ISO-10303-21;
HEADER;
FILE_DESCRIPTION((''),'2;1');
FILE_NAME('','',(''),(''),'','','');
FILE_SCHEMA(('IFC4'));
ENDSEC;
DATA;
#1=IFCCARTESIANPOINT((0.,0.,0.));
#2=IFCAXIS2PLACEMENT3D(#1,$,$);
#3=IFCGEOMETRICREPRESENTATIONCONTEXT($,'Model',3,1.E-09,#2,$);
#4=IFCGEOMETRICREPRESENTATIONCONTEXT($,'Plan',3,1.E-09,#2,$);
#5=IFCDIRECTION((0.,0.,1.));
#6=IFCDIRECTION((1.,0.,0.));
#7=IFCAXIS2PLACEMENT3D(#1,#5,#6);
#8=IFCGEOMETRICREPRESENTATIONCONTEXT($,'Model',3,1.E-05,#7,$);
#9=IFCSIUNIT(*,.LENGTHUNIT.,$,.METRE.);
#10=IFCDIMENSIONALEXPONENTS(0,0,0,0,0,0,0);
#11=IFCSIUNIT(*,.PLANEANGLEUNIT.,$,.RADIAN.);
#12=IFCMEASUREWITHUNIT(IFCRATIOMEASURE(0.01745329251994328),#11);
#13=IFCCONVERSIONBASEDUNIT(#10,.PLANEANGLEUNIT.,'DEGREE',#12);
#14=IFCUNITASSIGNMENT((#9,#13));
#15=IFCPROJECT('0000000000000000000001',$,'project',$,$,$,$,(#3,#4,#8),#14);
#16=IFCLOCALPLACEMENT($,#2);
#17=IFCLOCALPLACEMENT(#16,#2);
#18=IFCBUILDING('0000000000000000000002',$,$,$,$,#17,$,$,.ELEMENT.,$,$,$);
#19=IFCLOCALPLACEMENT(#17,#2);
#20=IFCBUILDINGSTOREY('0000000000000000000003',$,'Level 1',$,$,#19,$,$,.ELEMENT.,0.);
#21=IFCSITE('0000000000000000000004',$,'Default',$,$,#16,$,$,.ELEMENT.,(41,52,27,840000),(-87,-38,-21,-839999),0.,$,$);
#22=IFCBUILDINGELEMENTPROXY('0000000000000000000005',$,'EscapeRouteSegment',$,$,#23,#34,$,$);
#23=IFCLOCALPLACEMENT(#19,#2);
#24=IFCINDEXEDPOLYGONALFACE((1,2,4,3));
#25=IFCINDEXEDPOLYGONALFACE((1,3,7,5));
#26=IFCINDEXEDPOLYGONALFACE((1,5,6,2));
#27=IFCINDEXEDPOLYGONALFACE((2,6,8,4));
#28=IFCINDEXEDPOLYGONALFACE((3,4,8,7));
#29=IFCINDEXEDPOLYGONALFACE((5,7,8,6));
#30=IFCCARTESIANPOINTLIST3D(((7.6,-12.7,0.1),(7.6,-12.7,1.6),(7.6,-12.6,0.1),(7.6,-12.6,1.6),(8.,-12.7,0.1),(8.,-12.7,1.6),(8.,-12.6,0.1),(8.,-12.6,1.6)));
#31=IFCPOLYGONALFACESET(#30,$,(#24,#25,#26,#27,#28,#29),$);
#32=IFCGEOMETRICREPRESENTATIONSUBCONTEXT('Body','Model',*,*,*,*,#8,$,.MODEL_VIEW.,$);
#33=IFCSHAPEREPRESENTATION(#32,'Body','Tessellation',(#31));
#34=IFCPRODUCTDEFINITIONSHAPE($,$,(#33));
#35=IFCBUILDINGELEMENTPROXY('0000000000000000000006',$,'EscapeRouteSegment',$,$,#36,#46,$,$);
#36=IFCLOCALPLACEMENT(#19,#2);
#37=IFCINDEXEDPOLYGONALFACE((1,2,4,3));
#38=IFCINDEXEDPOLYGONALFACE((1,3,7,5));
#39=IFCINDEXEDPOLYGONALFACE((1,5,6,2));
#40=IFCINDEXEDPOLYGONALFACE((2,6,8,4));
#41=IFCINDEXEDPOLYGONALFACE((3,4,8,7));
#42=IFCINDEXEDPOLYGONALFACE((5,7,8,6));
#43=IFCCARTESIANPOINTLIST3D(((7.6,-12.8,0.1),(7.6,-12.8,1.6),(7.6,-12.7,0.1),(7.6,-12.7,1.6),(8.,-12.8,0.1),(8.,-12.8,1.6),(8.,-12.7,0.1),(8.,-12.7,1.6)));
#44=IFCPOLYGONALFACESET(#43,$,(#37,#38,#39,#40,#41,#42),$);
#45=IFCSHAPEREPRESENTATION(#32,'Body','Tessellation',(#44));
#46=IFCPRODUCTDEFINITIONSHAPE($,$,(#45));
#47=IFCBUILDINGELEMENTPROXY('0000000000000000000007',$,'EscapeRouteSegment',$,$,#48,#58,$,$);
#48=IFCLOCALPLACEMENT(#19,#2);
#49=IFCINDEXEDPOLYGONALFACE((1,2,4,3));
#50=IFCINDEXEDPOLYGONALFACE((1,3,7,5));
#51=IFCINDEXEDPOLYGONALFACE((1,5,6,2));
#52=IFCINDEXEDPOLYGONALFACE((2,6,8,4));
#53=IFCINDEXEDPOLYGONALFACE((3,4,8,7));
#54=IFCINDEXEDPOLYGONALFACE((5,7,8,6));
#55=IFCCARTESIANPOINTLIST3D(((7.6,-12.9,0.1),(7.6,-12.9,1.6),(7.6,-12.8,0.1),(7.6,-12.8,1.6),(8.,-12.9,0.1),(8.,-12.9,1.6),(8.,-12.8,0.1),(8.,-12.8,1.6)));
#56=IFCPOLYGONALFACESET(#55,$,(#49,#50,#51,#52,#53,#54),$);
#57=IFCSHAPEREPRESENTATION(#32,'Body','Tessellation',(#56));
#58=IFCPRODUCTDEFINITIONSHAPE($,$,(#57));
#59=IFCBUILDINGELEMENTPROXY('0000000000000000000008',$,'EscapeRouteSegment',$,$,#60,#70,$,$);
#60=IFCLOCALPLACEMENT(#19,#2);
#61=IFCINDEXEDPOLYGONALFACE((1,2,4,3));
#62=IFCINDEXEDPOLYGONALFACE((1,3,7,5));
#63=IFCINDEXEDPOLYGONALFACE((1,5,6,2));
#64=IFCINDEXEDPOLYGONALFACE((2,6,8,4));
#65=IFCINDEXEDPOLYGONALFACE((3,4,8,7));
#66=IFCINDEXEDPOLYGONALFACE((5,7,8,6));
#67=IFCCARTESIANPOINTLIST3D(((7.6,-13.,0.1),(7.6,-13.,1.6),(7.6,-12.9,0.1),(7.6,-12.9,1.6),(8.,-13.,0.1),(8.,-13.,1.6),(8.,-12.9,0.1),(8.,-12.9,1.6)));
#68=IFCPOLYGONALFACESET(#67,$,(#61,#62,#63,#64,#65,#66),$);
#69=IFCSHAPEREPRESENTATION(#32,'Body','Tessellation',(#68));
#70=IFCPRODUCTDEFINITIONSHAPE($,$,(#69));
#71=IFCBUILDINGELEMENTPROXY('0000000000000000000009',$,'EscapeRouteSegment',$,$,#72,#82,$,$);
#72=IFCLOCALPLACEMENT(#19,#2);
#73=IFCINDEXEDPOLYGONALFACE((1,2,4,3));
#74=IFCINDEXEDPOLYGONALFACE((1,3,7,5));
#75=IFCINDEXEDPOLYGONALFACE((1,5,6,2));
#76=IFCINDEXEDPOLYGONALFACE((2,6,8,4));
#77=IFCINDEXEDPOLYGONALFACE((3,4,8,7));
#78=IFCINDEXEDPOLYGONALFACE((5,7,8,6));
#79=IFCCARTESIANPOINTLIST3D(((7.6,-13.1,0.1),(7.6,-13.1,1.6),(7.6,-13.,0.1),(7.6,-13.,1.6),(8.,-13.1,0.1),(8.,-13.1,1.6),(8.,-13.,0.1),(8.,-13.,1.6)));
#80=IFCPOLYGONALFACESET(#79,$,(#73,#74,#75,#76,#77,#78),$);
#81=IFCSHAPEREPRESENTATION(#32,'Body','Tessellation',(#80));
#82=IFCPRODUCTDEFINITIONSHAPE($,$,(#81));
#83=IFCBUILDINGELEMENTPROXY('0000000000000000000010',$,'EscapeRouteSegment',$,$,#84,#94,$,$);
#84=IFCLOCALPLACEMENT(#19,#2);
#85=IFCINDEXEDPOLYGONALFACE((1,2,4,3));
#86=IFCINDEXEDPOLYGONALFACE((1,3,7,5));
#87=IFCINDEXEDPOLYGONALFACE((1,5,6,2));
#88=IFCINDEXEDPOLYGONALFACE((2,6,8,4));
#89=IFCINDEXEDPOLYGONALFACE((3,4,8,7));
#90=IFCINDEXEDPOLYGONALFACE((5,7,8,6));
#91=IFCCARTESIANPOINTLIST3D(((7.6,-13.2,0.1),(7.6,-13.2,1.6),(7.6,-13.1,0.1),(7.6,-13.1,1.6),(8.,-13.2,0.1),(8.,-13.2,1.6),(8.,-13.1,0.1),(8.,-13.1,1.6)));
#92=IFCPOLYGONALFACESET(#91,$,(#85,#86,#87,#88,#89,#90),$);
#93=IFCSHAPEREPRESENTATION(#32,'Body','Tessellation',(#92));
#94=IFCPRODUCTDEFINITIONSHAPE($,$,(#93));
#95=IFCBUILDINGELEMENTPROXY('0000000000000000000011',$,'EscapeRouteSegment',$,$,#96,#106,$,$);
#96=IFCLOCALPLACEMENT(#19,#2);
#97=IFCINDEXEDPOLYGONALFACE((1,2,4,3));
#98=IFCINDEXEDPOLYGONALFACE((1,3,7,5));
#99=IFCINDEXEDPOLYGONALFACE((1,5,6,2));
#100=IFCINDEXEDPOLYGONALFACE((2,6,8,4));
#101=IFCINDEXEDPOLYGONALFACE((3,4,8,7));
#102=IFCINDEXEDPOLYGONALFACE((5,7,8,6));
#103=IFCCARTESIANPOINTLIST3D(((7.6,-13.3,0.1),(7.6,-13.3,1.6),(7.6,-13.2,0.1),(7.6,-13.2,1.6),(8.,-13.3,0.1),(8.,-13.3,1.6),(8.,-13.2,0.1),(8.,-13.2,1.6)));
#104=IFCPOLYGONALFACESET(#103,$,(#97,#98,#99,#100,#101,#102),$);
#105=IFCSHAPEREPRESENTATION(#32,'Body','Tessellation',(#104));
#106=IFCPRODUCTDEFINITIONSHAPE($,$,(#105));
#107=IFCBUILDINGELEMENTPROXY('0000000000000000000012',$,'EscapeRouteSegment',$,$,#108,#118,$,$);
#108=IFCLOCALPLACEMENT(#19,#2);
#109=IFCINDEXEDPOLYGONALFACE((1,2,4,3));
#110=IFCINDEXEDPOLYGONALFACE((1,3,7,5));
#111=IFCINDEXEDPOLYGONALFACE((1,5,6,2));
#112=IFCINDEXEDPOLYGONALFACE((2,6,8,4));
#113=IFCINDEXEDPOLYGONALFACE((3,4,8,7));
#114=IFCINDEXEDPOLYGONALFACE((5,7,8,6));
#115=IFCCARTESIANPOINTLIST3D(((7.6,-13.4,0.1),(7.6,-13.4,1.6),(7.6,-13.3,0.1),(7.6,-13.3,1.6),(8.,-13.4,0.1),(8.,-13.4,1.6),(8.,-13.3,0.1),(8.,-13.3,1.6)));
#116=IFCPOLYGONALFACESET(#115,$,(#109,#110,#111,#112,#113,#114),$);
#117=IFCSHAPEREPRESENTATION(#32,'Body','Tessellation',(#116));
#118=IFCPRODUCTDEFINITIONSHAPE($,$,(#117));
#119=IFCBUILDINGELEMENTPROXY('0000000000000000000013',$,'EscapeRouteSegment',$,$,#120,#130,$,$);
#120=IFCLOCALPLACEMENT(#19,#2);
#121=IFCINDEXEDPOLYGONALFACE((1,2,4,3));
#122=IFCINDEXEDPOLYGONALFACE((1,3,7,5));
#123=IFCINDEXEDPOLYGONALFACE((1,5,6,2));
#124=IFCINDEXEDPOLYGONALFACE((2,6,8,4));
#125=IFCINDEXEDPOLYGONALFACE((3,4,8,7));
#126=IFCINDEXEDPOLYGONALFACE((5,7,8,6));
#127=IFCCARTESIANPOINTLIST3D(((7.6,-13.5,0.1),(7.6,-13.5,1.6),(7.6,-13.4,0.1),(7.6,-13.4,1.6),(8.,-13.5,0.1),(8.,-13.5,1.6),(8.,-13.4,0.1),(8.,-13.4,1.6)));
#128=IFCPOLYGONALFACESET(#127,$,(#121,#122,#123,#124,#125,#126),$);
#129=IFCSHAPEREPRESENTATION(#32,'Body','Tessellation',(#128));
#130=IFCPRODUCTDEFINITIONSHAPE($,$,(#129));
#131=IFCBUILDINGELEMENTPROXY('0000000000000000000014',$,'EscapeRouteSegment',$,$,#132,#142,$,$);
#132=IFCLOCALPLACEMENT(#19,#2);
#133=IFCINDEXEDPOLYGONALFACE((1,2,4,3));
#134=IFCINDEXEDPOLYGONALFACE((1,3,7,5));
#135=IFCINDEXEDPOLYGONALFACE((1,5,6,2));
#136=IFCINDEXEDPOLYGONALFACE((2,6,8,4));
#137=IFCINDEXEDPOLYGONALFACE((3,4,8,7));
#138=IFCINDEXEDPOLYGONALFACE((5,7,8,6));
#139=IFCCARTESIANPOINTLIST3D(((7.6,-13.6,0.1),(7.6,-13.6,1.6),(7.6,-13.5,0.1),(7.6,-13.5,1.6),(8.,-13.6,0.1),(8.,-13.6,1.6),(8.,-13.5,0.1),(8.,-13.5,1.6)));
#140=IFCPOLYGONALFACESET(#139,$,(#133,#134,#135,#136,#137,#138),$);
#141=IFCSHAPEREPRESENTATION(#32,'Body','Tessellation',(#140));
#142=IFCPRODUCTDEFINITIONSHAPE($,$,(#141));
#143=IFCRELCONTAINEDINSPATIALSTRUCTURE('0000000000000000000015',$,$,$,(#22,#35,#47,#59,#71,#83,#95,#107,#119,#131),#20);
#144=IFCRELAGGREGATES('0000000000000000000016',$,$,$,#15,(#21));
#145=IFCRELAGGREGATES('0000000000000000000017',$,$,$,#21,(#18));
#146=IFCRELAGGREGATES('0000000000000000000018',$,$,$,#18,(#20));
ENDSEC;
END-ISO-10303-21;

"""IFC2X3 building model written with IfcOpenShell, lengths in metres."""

from ifc_helpers import new_model, entity, si_unit, converted_unit, frame, origin, origin_with_axes, place, context, subcontext, project, spatial, polyline, outline, extrude, element, save


model = new_model("IFC2X3")

# Units and contexts
model_context_1 = context("Model", 3, precision=1e-09, world=origin())
plan_context = context("Plan", 3, precision=1e-09, world=origin())
model_context_2 = context("Model", 3, precision=1e-05, world=origin_with_axes())
body_context = subcontext(model_context_2, "Body", "Model", "MODEL_VIEW")
ifc_project = project(units=[si_unit("LENGTHUNIT", "METRE"), converted_unit("PLANEANGLEUNIT", "DEGREE", entity("IfcRatioMeasure", 0.01745329251994328), si_unit("PLANEANGLEUNIT", "RADIAN"), dimensions=[0, 0, 0, 0, 0, 0, 0])], contexts=[model_context_1, plan_context, model_context_2])

# Site, building, storey
site_placement = place(None, origin())
site = spatial("IfcSite", under=ifc_project, at=site_placement, Name="Default", CompositionType="ELEMENT", RefLatitude=(41, 52, 27, 840000), RefLongitude=(-87, -38, -21, -839999), RefElevation=0.0)
building_placement = place(site_placement, origin())
building = spatial("IfcBuilding", under=site, at=building_placement, CompositionType="ELEMENT")
storey_placement = place(building_placement, origin())
storey = spatial("IfcBuildingStorey", under=building, at=storey_placement, Name="Level 1", CompositionType="ELEMENT", Elevation=0.0)

# Building element proxies
proxy_1_placement = place(storey_placement, frame((7.8, -12.6, 0.1), z_axis=(0.0, 0.0, 1.0), x_axis=(0.0, -1.0, 0.0)))
element("IfcBuildingElementProxy", 1, at=proxy_1_placement, inside=storey, Name="EscapeRouteSegment", context=body_context, shape_type="SweptSolid", body=[
    extrude(outline(polyline([(0.0, -0.2), (0.0, 0.2), (0.1, 0.2), (0.1, -0.2), (0.0, -0.2)])), origin_with_axes(), (0.0, 0.0, 1.0), 1.5),
])
proxy_2_placement = place(storey_placement, frame((7.8, -12.7, 0.1), z_axis=(0.0, 0.0, 1.0), x_axis=(0.0, -1.0, 0.0)))
element("IfcBuildingElementProxy", 2, at=proxy_2_placement, inside=storey, Name="EscapeRouteSegment", context=body_context, shape_type="SweptSolid", body=[
    extrude(outline(polyline([(0.0, -0.2), (0.0, 0.2), (0.1, 0.2), (0.1, -0.2), (0.0, -0.2)])), origin_with_axes(), (0.0, 0.0, 1.0), 1.5),
])
proxy_3_placement = place(storey_placement, frame((7.8, -12.8, 0.1), z_axis=(0.0, 0.0, 1.0), x_axis=(0.0, -1.0, 0.0)))
element("IfcBuildingElementProxy", 3, at=proxy_3_placement, inside=storey, Name="EscapeRouteSegment", context=body_context, shape_type="SweptSolid", body=[
    extrude(outline(polyline([(0.0, -0.2), (0.0, 0.2), (0.1, 0.2), (0.1, -0.2), (0.0, -0.2)])), origin_with_axes(), (0.0, 0.0, 1.0), 1.5),
])
for number, where, z_axis, x_axis, name in (
    (4, (7.8, -12.9, 0.1), (0.0, 0.0, 1.0), (0.0, -1.0, 0.0), "EscapeRouteSegment"),
    (5, (7.8, -13.0, 0.1), (0.0, 0.0, 1.0), (0.0, -1.0, 0.0), "EscapeRouteSegment"),
):
    element("IfcBuildingElementProxy", number, at=place(storey_placement, frame(where, z_axis=z_axis, x_axis=x_axis)), inside=storey, Name=name, context=body_context, shape_type="SweptSolid", body=[
        extrude(outline(polyline([(0.0, -0.2), (0.0, 0.2), (0.1, 0.2), (0.1, -0.2), (0.0, -0.2)])), origin_with_axes(), (0.0, 0.0, 1.0), 1.5),
    ])
proxy_4_placement = place(storey_placement, frame((7.8, -13.1, 0.1), z_axis=(0.0, 0.0, 1.0), x_axis=(0.0, -1.0, 0.0)))
element("IfcBuildingElementProxy", 6, at=proxy_4_placement, inside=storey, Name="EscapeRouteSegment", context=body_context, shape_type="SweptSolid", body=[
    extrude(outline(polyline([(0.0, -0.2), (0.0, 0.2), (0.1, 0.2), (0.1, -0.2), (0.0, -0.2)])), origin_with_axes(), (0.0, 0.0, 1.0), 1.5),
])
proxy_5_placement = place(storey_placement, frame((7.8, -13.2, 0.1), z_axis=(0.0, 0.0, 1.0), x_axis=(0.0, -1.0, 0.0)))
element("IfcBuildingElementProxy", 7, at=proxy_5_placement, inside=storey, Name="EscapeRouteSegment", context=body_context, shape_type="SweptSolid", body=[
    extrude(outline(polyline([(0.0, -0.2), (0.0, 0.2), (0.1, 0.2), (0.1, -0.2), (0.0, -0.2)])), origin_with_axes(), (0.0, 0.0, 1.0), 1.5),
])
proxy_6_placement = place(storey_placement, frame((7.8, -13.3, 0.1), z_axis=(0.0, 0.0, 1.0), x_axis=(0.0, -1.0, 0.0)))
element("IfcBuildingElementProxy", 8, at=proxy_6_placement, inside=storey, Name="EscapeRouteSegment", context=body_context, shape_type="SweptSolid", body=[
    extrude(outline(polyline([(0.0, -0.2), (0.0, 0.2), (0.1, 0.2), (0.1, -0.2), (0.0, -0.2)])), origin_with_axes(), (0.0, 0.0, 1.0), 1.5),
])
proxy_7_placement = place(storey_placement, frame((7.8, -13.4, 0.1), z_axis=(0.0, 0.0, 1.0), x_axis=(0.0, -1.0, 0.0)))
element("IfcBuildingElementProxy", 9, at=proxy_7_placement, inside=storey, Name="EscapeRouteSegment", context=body_context, shape_type="SweptSolid", body=[
    extrude(outline(polyline([(0.0, -0.2), (0.0, 0.2), (0.1, 0.2), (0.1, -0.2), (0.0, -0.2)])), origin_with_axes(), (0.0, 0.0, 1.0), 1.5),
])
for number, where, z_axis, x_axis, name in (
    (10, (7.8, -13.5, 0.1), (0.0, 0.0, 1.0), (0.0, -1.0, 0.0), "EscapeRouteSegment"),
):
    element("IfcBuildingElementProxy", number, at=place(storey_placement, frame(where, z_axis=z_axis, x_axis=x_axis)), inside=storey, Name=name, context=body_context, shape_type="SweptSolid", body=[
        extrude(outline(polyline([(0.0, -0.2), (0.0, 0.2), (0.1, 0.2), (0.1, -0.2), (0.0, -0.2)])), origin_with_axes(), (0.0, 0.0, 1.0), 1.5),
    ])

save(model, "model.ifc")
